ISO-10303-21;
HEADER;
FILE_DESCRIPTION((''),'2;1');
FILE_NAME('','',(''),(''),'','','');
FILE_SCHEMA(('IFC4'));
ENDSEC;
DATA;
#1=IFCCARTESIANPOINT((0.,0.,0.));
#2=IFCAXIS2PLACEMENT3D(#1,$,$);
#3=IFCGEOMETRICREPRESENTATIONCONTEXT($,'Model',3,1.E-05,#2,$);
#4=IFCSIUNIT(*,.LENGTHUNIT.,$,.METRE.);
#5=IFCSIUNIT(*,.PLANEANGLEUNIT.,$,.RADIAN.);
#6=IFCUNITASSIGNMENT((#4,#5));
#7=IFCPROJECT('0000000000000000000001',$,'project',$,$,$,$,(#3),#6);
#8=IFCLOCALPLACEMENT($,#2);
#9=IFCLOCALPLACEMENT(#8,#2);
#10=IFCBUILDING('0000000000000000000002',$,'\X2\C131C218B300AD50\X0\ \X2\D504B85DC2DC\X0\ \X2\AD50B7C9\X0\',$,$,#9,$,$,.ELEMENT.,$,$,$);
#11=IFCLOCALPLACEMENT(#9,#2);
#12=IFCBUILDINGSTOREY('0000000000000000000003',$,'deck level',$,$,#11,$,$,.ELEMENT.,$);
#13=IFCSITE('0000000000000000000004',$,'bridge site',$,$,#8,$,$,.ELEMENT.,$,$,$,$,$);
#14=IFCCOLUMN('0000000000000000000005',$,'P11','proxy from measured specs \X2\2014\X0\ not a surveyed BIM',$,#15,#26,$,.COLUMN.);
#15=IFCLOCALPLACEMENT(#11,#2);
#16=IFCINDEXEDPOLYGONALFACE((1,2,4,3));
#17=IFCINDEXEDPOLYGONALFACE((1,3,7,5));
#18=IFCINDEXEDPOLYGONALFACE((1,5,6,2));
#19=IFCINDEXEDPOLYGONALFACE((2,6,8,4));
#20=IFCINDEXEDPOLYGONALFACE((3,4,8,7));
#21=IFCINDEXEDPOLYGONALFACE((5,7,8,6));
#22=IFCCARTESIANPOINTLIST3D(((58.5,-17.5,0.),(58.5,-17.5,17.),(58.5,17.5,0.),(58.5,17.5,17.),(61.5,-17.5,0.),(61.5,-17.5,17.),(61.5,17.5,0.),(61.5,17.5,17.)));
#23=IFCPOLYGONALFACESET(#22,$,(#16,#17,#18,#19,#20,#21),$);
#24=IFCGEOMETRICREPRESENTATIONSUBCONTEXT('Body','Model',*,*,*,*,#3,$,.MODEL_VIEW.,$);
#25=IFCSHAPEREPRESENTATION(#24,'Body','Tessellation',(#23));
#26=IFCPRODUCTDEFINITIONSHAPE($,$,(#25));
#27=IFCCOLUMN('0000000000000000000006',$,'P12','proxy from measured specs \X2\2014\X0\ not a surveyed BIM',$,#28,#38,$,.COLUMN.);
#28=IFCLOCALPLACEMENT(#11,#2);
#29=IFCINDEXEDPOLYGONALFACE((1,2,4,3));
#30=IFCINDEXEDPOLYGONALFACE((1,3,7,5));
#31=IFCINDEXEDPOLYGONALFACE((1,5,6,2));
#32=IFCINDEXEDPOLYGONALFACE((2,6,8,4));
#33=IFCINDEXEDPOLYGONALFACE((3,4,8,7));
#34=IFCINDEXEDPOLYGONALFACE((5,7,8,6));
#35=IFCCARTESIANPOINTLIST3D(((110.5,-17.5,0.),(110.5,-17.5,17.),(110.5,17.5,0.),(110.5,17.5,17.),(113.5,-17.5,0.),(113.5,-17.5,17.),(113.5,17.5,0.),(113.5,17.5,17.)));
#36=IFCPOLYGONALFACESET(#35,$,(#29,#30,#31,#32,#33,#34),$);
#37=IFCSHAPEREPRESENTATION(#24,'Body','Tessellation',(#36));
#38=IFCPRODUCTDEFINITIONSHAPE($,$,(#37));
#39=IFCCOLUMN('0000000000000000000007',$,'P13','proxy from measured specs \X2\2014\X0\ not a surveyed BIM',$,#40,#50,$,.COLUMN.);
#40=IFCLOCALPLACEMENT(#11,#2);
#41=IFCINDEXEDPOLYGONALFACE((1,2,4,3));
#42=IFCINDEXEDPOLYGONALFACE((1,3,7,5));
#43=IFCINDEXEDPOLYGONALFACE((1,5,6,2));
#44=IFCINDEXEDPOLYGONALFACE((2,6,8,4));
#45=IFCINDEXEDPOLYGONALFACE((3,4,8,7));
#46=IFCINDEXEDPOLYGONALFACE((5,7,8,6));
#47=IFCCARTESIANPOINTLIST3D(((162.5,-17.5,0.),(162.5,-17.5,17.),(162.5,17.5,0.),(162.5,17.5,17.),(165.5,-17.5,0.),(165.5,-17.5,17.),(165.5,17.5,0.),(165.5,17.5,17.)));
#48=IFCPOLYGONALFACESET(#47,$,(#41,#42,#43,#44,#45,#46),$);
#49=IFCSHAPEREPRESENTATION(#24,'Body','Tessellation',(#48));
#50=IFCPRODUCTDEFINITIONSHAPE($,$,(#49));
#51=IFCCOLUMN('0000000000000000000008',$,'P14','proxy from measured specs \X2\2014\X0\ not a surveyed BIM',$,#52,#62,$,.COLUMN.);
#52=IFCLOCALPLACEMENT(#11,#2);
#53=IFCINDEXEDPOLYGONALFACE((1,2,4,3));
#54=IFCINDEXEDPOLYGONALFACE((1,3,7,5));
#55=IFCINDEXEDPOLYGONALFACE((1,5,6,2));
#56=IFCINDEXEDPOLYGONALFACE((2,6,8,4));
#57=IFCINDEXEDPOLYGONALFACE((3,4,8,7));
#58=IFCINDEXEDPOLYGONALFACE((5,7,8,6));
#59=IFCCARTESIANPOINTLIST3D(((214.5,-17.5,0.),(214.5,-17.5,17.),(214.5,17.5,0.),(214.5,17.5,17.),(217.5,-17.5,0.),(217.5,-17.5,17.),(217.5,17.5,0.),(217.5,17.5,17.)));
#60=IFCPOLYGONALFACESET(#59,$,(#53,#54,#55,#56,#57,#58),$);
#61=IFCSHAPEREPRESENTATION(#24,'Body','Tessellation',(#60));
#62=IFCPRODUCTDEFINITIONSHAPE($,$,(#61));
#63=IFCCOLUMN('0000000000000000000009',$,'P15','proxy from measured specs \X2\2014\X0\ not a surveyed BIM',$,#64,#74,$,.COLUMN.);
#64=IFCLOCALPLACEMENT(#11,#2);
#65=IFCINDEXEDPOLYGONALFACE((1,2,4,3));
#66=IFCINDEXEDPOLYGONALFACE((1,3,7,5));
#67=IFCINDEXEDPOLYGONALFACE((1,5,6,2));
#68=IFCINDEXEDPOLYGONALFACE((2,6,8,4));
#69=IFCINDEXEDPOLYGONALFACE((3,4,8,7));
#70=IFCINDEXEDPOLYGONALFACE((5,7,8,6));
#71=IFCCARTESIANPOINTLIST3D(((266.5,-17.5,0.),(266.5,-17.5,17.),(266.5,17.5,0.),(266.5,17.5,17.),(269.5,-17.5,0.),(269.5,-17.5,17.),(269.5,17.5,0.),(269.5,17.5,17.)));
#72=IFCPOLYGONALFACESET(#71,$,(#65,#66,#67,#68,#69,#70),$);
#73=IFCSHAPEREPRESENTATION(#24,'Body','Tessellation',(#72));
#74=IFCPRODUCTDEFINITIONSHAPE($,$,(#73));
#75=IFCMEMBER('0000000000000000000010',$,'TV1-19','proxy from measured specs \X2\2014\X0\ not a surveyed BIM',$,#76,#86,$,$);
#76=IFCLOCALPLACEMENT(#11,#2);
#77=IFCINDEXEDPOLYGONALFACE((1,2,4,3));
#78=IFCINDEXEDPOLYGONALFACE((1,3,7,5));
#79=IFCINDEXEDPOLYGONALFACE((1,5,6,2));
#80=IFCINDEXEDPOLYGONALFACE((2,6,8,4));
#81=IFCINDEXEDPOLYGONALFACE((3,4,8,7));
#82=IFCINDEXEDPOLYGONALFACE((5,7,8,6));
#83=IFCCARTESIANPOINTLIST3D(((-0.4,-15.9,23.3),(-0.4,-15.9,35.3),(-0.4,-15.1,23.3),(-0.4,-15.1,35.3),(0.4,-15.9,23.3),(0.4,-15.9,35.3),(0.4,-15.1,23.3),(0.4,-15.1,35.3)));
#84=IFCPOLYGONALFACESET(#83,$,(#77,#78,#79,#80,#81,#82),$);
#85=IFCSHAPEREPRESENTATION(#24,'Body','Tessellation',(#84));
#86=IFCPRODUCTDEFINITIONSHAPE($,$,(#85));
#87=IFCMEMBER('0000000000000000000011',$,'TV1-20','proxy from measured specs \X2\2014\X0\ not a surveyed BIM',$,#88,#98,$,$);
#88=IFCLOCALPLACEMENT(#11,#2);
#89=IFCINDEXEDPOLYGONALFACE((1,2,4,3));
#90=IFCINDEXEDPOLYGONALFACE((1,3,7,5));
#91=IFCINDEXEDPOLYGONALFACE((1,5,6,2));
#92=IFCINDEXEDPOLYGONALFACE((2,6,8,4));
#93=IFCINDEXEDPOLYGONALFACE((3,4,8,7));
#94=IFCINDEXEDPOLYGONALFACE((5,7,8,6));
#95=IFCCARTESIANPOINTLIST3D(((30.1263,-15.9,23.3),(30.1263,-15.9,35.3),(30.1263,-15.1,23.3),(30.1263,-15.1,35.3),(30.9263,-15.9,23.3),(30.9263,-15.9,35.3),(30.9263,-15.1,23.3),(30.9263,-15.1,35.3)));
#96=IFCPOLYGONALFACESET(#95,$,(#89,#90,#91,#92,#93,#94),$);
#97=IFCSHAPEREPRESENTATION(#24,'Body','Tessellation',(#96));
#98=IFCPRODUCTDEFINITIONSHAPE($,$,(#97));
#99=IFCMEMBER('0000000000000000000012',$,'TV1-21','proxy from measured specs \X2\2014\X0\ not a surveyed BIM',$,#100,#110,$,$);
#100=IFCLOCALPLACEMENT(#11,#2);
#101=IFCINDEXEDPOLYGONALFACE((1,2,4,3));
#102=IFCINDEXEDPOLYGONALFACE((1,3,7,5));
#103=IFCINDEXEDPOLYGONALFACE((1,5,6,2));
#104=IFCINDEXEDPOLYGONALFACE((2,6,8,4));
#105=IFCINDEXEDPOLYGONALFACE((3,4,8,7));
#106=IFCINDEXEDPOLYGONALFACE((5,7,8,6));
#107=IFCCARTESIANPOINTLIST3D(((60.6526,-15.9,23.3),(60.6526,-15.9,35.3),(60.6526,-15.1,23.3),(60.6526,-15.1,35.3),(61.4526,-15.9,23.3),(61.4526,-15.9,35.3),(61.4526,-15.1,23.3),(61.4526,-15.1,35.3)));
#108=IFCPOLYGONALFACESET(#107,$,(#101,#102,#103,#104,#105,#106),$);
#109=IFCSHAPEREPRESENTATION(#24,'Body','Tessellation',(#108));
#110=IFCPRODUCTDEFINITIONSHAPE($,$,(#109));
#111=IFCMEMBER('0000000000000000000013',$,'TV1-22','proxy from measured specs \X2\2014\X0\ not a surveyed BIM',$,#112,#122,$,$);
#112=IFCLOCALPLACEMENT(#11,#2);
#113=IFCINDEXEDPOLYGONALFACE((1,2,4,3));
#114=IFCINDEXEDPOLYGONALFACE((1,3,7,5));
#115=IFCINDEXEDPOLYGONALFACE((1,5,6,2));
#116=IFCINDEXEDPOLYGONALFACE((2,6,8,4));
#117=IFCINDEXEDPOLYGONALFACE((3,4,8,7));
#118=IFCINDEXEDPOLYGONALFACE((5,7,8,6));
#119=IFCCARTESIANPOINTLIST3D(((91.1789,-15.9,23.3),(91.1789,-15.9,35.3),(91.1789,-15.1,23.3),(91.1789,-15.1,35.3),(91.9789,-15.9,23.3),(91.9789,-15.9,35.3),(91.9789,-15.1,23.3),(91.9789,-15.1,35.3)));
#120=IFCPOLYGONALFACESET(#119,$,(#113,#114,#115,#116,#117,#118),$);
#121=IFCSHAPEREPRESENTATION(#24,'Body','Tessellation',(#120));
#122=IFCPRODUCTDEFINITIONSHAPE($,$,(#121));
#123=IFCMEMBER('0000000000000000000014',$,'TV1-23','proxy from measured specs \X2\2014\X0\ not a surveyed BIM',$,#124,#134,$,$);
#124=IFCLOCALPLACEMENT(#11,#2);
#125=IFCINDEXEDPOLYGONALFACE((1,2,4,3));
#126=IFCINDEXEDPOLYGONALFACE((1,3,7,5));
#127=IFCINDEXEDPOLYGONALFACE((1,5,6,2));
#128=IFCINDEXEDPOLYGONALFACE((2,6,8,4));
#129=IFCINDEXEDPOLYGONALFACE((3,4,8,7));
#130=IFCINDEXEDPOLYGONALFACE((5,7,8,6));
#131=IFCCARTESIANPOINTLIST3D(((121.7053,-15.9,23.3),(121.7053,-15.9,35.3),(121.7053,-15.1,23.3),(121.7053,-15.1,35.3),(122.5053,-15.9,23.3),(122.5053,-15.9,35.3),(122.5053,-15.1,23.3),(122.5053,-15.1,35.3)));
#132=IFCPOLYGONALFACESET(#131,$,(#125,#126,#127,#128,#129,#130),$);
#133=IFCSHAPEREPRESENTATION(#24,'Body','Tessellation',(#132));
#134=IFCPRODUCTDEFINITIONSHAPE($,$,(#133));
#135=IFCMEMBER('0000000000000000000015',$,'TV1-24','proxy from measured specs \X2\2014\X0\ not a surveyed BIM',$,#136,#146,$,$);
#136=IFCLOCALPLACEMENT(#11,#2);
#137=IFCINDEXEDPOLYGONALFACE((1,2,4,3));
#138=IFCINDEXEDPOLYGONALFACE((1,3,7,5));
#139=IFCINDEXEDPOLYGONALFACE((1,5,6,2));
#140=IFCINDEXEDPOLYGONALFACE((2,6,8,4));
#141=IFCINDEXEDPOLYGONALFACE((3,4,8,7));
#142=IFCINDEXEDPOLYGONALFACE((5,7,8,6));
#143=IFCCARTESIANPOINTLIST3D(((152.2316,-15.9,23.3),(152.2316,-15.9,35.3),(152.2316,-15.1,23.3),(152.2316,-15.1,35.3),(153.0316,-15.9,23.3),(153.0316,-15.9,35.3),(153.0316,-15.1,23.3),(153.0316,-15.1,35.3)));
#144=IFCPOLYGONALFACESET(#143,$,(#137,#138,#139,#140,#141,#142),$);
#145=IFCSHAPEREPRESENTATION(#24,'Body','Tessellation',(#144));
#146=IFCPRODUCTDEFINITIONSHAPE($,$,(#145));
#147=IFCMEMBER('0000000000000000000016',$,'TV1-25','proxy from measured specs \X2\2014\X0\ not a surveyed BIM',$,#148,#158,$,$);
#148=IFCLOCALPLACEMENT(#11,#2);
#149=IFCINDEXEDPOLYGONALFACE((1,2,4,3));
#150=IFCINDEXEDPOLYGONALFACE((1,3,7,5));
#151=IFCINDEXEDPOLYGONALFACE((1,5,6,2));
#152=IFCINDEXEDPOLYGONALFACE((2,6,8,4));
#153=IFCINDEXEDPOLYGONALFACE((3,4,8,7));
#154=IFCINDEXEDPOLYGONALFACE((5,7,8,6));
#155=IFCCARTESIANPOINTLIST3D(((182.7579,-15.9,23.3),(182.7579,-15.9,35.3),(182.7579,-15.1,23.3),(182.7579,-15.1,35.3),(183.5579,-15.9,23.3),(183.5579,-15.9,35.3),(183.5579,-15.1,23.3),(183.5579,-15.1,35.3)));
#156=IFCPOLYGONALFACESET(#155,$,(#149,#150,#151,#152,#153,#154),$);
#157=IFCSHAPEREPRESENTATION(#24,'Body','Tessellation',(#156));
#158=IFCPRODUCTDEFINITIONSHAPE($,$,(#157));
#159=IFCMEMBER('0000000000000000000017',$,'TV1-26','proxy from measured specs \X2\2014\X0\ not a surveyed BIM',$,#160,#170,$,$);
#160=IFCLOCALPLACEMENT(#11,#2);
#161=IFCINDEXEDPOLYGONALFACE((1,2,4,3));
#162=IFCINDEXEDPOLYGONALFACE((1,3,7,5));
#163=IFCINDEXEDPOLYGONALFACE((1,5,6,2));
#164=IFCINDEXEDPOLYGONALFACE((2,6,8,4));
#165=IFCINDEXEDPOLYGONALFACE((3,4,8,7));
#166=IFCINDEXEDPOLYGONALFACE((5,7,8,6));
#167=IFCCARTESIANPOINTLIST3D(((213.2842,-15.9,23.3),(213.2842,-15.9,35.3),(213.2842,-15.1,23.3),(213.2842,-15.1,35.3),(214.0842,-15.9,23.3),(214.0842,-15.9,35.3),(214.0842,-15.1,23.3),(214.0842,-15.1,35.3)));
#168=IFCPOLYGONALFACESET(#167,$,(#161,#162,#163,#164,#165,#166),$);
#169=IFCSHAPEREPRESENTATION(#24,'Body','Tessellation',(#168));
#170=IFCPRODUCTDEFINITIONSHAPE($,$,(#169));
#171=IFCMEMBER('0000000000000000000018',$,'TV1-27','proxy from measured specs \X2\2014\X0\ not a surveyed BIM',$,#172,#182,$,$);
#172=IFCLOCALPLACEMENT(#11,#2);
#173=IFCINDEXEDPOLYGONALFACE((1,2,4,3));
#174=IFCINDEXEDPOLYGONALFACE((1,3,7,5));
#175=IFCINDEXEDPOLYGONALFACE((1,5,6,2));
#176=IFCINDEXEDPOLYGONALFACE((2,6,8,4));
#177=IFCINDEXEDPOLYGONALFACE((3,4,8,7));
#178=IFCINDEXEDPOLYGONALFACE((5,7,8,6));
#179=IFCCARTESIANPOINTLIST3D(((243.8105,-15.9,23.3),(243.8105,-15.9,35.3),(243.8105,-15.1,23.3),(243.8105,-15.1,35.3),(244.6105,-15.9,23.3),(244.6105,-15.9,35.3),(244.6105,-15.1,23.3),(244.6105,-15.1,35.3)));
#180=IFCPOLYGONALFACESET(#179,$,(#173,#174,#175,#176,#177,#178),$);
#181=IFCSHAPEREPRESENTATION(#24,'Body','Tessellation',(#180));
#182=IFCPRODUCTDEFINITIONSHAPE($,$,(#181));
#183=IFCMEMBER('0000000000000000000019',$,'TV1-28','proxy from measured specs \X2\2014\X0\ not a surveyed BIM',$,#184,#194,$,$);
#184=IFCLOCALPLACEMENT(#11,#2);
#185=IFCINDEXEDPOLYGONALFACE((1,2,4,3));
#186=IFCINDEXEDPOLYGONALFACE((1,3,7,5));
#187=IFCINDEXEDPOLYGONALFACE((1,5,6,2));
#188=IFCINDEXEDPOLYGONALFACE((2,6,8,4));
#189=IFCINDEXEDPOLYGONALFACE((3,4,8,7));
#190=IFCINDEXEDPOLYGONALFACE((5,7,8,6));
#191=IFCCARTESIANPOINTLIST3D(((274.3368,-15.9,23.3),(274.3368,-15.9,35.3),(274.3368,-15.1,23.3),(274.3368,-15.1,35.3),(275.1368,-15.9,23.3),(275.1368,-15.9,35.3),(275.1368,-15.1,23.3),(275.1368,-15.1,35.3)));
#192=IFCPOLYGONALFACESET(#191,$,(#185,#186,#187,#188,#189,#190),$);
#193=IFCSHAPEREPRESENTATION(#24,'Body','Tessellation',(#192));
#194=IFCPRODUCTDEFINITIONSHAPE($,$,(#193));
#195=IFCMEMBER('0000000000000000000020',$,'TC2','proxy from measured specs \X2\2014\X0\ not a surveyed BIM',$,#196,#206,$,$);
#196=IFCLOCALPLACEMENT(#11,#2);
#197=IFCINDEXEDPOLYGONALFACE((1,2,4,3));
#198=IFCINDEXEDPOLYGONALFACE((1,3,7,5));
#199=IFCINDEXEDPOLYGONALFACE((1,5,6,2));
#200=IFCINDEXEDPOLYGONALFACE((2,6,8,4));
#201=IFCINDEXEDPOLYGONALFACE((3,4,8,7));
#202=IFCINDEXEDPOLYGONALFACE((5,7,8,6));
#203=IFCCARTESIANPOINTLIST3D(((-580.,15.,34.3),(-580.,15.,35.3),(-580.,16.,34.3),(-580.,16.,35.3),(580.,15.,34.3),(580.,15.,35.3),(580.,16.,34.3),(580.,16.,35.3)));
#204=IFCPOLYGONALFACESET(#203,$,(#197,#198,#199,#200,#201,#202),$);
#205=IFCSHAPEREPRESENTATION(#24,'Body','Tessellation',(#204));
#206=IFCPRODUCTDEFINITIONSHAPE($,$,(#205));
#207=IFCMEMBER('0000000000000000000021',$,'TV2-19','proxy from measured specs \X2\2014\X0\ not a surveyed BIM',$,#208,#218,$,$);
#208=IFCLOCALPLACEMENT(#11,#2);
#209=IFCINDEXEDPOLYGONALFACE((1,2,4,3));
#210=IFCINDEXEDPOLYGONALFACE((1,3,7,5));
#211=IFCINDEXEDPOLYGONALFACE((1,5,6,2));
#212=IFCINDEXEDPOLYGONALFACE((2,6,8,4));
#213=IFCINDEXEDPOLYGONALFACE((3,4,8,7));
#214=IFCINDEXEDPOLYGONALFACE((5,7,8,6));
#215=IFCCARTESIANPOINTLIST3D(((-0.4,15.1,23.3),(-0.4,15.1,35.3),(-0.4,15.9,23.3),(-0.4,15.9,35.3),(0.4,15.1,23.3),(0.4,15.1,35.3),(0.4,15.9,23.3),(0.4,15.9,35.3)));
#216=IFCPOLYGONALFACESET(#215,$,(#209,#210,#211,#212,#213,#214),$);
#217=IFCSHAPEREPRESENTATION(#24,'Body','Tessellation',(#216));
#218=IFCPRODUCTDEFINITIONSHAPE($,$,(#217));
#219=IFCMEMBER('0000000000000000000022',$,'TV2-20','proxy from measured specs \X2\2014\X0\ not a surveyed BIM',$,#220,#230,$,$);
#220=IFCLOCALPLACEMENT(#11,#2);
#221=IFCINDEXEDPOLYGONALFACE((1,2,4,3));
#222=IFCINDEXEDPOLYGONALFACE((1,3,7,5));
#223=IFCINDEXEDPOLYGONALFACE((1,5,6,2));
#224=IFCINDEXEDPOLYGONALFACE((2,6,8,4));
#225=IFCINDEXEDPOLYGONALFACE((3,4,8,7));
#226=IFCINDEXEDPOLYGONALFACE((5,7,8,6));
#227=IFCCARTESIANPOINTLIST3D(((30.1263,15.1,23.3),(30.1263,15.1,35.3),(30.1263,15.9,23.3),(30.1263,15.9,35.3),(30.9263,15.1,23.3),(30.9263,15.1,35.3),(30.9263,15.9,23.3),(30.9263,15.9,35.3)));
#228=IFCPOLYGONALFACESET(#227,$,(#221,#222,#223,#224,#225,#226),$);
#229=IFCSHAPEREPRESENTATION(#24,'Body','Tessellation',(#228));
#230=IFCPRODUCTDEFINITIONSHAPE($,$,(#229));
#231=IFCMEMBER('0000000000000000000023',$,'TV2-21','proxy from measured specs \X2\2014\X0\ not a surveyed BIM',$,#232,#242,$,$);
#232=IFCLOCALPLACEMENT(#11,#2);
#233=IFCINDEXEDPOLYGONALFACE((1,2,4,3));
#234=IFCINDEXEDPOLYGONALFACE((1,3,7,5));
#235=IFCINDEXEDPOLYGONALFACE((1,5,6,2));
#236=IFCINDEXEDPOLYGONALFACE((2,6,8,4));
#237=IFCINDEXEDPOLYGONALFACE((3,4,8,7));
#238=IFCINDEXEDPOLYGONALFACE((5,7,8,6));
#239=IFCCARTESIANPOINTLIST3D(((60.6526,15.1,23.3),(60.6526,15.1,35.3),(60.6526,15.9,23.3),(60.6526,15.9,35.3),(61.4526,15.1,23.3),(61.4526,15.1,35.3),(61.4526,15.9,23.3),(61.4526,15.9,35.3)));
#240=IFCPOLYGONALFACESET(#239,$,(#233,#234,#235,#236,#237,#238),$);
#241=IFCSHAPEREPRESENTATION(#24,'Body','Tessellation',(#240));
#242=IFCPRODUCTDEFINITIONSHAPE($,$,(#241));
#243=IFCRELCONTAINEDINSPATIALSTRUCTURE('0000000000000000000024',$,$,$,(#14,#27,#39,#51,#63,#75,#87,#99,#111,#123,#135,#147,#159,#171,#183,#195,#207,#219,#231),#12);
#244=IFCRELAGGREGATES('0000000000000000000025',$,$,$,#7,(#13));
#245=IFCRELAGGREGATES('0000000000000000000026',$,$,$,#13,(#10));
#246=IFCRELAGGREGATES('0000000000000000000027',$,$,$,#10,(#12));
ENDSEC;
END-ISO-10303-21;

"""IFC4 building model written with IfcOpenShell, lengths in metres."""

from ifc_helpers import new_model, si_unit, frame, origin, origin_2d, place, context, subcontext, project, spatial, rectangle, extrude, element, save


model = new_model("IFC4")

# Units and contexts
model_context = context("Model", 3, precision=1e-05, world=origin())
body_context = subcontext(model_context, "Body", "Model", "MODEL_VIEW")
ifc_project = project(units=[si_unit("LENGTHUNIT", "METRE"), si_unit("PLANEANGLEUNIT", "RADIAN")], contexts=[model_context])

# Site, building, storey
site_placement = place(None, origin())
site = spatial("IfcSite", under=ifc_project, at=site_placement, Name="bridge site", CompositionType="ELEMENT")
building_placement = place(site_placement, origin())
building = spatial("IfcBuilding", under=site, at=building_placement, Name="성수대교 프록시 교량", CompositionType="ELEMENT")
storey_placement = place(building_placement, origin())
storey = spatial("IfcBuildingStorey", under=building, at=storey_placement, Name="deck level", CompositionType="ELEMENT")

# Columns
for number, where, name in (
    (1, (60.0, 0.0, 0.0), "P11"),
    (2, (112.0, 0.0, 0.0), "P12"),
    (3, (164.0, 0.0, 0.0), "P13"),
    (4, (216.0, 0.0, 0.0), "P14"),
    (5, (268.0, 0.0, 0.0), "P15"),
):
    element("IfcColumn", number, at=place(storey_placement, frame(where)), inside=storey, Name=name, Description="proxy from measured specs — not a surveyed BIM", PredefinedType="COLUMN", context=body_context, shape_type="SweptSolid", body=[
        extrude(rectangle(XDim=3.0, YDim=35.0, at=origin_2d()), origin(), (0.0, 0.0, 1.0), 17.0),
    ])

# Members
member_1_placement = place(storey_placement, frame((0.0, -15.5, 23.3)))
element("IfcMember", 6, at=member_1_placement, inside=storey, Name="TV1-19", Description="proxy from measured specs — not a surveyed BIM", context=body_context, shape_type="SweptSolid", body=[
    extrude(rectangle(XDim=0.8, YDim=0.8, at=origin_2d()), origin(), (0.0, 0.0, 1.0), 12.0),
])
for number, where, name in (
    (7, (30.5263, -15.5, 23.3), "TV1-20"),
    (8, (61.0526, -15.5, 23.3), "TV1-21"),
):
    element("IfcMember", number, at=place(storey_placement, frame(where)), inside=storey, Name=name, Description="proxy from measured specs — not a surveyed BIM", context=body_context, shape_type="SweptSolid", body=[
        extrude(rectangle(XDim=0.8, YDim=0.8, at=origin_2d()), origin(), (0.0, 0.0, 1.0), 12.0),
    ])
for number, where, name in (
    (9, (91.5789, -15.5, 23.3), "TV1-22"),
    (10, (122.1053, -15.5, 23.3), "TV1-23"),
    (11, (152.6316, -15.5, 23.3), "TV1-24"),
    (12, (183.1579, -15.5, 23.3), "TV1-25"),
    (13, (213.6842, -15.5, 23.3), "TV1-26"),
    (14, (244.2105, -15.5, 23.3), "TV1-27"),
):
    element("IfcMember", number, at=place(storey_placement, frame(where)), inside=storey, Name=name, Description="proxy from measured specs — not a surveyed BIM", context=body_context, shape_type="SweptSolid", body=[
        extrude(rectangle(XDim=0.8, YDim=0.8, at=origin_2d()), origin(), (0.0, 0.0, 1.0), 12.0),
    ])
member_2_placement = place(storey_placement, frame((274.7368, -15.5, 23.3)))
element("IfcMember", 15, at=member_2_placement, inside=storey, Name="TV1-28", Description="proxy from measured specs — not a surveyed BIM", context=body_context, shape_type="SweptSolid", body=[
    extrude(rectangle(XDim=0.8, YDim=0.8, at=origin_2d()), origin(), (0.0, 0.0, 1.0), 12.0),
])
member_3_placement = place(storey_placement, frame((0.0, 15.5, 34.3)))
element("IfcMember", 16, at=member_3_placement, inside=storey, Name="TC2", Description="proxy from measured specs — not a surveyed BIM", context=body_context, shape_type="SweptSolid", body=[
    extrude(rectangle(XDim=1160.0, YDim=1.0, at=origin_2d()), origin(), (0.0, 0.0, 1.0), 1.0),
])
member_4_placement = place(storey_placement, frame((0.0, 15.5, 23.3)))
element("IfcMember", 17, at=member_4_placement, inside=storey, Name="TV2-19", Description="proxy from measured specs — not a surveyed BIM", context=body_context, shape_type="SweptSolid", body=[
    extrude(rectangle(XDim=0.8, YDim=0.8, at=origin_2d()), origin(), (0.0, 0.0, 1.0), 12.0),
])
for number, where, name in (
    (18, (30.5263, 15.5, 23.3), "TV2-20"),
    (19, (61.0526, 15.5, 23.3), "TV2-21"),
):
    element("IfcMember", number, at=place(storey_placement, frame(where)), inside=storey, Name=name, Description="proxy from measured specs — not a surveyed BIM", context=body_context, shape_type="SweptSolid", body=[
        extrude(rectangle(XDim=0.8, YDim=0.8, at=origin_2d()), origin(), (0.0, 0.0, 1.0), 12.0),
    ])

save(model, "model.ifc")
